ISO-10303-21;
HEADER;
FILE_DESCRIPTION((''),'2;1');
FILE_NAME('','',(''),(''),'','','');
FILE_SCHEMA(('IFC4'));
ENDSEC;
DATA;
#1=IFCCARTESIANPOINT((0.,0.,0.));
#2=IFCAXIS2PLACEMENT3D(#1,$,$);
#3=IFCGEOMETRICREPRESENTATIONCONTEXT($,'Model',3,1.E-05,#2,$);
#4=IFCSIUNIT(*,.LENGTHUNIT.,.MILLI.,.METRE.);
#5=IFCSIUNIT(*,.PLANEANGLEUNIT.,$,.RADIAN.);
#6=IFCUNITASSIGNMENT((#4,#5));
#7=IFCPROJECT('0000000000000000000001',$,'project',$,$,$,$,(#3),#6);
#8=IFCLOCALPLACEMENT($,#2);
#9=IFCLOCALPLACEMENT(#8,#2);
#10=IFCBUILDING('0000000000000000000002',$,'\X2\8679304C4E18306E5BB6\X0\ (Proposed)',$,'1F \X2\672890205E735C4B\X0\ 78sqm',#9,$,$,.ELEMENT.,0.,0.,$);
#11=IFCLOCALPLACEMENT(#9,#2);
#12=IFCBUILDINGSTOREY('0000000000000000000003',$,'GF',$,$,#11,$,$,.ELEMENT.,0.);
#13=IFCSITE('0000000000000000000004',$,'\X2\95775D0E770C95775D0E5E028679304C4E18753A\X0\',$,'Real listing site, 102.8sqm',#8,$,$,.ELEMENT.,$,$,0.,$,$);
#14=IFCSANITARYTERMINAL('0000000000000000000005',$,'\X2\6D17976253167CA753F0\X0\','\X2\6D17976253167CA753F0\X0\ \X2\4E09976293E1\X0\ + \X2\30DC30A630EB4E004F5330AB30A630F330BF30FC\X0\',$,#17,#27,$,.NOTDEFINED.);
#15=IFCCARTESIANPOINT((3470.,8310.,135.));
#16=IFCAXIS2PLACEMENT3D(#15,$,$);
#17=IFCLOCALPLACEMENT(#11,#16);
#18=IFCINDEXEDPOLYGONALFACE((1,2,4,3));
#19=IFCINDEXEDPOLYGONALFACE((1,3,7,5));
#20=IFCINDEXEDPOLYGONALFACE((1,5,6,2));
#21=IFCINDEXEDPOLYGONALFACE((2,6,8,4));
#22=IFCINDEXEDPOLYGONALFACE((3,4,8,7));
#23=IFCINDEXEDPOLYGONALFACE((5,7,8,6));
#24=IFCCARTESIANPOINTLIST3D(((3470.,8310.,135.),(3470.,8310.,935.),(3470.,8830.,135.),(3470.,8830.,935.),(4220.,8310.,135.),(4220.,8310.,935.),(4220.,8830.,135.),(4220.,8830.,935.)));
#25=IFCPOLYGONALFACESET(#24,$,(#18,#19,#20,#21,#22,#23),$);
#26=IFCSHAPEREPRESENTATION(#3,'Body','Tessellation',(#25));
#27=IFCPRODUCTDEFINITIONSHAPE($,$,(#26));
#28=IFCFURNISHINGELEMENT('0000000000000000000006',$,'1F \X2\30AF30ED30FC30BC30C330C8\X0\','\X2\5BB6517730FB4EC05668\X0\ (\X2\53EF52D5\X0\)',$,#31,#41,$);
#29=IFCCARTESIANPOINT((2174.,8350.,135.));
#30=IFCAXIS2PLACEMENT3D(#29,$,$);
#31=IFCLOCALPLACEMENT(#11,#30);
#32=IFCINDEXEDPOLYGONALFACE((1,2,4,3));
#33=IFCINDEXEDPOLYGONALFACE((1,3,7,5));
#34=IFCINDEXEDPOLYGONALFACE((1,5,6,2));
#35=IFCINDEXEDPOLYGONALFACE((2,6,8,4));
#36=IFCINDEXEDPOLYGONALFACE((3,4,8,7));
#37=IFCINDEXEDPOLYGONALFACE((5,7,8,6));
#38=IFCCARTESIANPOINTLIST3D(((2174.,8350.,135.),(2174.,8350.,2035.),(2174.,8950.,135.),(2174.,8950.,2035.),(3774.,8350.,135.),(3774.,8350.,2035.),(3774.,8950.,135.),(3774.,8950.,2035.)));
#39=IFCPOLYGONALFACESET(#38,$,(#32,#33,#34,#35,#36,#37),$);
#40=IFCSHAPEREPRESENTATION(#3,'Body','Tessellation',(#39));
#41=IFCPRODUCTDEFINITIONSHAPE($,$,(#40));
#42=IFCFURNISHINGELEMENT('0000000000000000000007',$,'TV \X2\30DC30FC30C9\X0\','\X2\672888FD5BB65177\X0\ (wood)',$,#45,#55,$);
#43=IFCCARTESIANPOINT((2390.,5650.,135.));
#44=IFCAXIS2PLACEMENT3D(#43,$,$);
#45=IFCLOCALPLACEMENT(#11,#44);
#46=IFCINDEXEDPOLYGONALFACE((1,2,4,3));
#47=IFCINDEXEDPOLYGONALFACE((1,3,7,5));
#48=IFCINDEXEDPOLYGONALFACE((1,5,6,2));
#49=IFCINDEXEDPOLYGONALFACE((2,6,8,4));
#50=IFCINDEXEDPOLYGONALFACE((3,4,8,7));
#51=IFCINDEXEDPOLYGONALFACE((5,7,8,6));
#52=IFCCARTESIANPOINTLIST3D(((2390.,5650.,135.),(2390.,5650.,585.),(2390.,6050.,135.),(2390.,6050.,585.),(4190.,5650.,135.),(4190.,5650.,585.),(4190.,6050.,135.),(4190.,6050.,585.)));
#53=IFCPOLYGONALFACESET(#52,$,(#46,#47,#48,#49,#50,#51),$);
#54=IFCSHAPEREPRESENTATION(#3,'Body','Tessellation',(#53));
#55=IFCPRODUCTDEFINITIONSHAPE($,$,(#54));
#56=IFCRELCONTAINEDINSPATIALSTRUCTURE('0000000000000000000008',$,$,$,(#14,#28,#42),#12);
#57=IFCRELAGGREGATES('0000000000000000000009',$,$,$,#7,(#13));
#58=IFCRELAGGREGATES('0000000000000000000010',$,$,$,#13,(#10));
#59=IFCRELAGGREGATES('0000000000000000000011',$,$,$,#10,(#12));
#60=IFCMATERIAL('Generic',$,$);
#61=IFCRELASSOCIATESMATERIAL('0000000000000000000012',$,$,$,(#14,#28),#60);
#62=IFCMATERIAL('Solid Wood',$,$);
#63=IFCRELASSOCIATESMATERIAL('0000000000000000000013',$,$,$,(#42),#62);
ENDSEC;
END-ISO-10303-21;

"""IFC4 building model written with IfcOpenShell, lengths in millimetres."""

from ifc_helpers import new_model, si_unit, frame, frame_2d, origin, place, context, project, spatial, rectangle, extrude, material, element, save


model = new_model("IFC4")

# Units and contexts
model_context = context("Model", 3, precision=1e-05, world=origin())
ifc_project = project(units=[si_unit("LENGTHUNIT", "METRE", prefix="MILLI"), si_unit("PLANEANGLEUNIT", "RADIAN")], contexts=[model_context])

# Site, building, storey
site_placement = place(None, origin())
site = spatial("IfcSite", under=ifc_project, at=site_placement, Name="長崎県長崎市虹が丘町", ObjectType="Real listing site, 102.8sqm", CompositionType="ELEMENT", RefElevation=0.0)
building_placement = place(site_placement, origin())
building = spatial("IfcBuilding", under=site, at=building_placement, Name="虹が丘の家 (Proposed)", ObjectType="1F 木造平屋 78sqm", CompositionType="ELEMENT", ElevationOfRefHeight=0.0, ElevationOfTerrain=0.0)
storey_placement = place(building_placement, origin())
storey = spatial("IfcBuildingStorey", under=building, at=storey_placement, Name="GF", CompositionType="ELEMENT", Elevation=0.0)

# Shared definitions
ifc_material_1 = material(Name="Solid Wood")

# Shared definitions
ifc_material_2 = material(Name="Generic")

# Sanitary terminal
sanitary_terminal_1_placement = place(storey_placement, frame((3470.0, 8310.0, 135.0)))
element("IfcSanitaryTerminal", 1, at=sanitary_terminal_1_placement, inside=storey, material=ifc_material_2, Name="洗面化粧台", Description="洗面化粧台 三面鏡 + ボウル一体カウンター", PredefinedType="NOTDEFINED", context=model_context, shape_type="SweptSolid", body=[
    extrude(rectangle(XDim=750.0, YDim=520.0, at=frame_2d((375.0, 260.0))), frame((3470.0, 8310.0, 135.0)), (0.0, 0.0, 1.0), 800.0),
])

# Furnishing elements
furnishing_1_placement = place(storey_placement, frame((2174.0, 8350.0, 135.0)))
element("IfcFurnishingElement", 2, at=furnishing_1_placement, inside=storey, material=ifc_material_2, Name="1F クローゼット", Description="家具・什器 (可動)", context=model_context, shape_type="SweptSolid", body=[
    extrude(rectangle(XDim=1600.0, YDim=600.0, at=frame_2d((800.0, 300.0))), frame((2174.0, 8350.0, 135.0)), (0.0, 0.0, 1.0), 1900.0),
])
furnishing_2_placement = place(storey_placement, frame((2390.0, 5650.0, 135.0)))
element("IfcFurnishingElement", 3, at=furnishing_2_placement, inside=storey, material=ifc_material_1, Name="TV ボード", Description="木製家具 (wood)", context=model_context, shape_type="SweptSolid", body=[
    extrude(rectangle(XDim=1800.0, YDim=400.0, at=frame_2d((900.0, 200.0))), frame((2390.0, 5650.0, 135.0)), (0.0, 0.0, 1.0), 450.0),
])

save(model, "model.ifc")
